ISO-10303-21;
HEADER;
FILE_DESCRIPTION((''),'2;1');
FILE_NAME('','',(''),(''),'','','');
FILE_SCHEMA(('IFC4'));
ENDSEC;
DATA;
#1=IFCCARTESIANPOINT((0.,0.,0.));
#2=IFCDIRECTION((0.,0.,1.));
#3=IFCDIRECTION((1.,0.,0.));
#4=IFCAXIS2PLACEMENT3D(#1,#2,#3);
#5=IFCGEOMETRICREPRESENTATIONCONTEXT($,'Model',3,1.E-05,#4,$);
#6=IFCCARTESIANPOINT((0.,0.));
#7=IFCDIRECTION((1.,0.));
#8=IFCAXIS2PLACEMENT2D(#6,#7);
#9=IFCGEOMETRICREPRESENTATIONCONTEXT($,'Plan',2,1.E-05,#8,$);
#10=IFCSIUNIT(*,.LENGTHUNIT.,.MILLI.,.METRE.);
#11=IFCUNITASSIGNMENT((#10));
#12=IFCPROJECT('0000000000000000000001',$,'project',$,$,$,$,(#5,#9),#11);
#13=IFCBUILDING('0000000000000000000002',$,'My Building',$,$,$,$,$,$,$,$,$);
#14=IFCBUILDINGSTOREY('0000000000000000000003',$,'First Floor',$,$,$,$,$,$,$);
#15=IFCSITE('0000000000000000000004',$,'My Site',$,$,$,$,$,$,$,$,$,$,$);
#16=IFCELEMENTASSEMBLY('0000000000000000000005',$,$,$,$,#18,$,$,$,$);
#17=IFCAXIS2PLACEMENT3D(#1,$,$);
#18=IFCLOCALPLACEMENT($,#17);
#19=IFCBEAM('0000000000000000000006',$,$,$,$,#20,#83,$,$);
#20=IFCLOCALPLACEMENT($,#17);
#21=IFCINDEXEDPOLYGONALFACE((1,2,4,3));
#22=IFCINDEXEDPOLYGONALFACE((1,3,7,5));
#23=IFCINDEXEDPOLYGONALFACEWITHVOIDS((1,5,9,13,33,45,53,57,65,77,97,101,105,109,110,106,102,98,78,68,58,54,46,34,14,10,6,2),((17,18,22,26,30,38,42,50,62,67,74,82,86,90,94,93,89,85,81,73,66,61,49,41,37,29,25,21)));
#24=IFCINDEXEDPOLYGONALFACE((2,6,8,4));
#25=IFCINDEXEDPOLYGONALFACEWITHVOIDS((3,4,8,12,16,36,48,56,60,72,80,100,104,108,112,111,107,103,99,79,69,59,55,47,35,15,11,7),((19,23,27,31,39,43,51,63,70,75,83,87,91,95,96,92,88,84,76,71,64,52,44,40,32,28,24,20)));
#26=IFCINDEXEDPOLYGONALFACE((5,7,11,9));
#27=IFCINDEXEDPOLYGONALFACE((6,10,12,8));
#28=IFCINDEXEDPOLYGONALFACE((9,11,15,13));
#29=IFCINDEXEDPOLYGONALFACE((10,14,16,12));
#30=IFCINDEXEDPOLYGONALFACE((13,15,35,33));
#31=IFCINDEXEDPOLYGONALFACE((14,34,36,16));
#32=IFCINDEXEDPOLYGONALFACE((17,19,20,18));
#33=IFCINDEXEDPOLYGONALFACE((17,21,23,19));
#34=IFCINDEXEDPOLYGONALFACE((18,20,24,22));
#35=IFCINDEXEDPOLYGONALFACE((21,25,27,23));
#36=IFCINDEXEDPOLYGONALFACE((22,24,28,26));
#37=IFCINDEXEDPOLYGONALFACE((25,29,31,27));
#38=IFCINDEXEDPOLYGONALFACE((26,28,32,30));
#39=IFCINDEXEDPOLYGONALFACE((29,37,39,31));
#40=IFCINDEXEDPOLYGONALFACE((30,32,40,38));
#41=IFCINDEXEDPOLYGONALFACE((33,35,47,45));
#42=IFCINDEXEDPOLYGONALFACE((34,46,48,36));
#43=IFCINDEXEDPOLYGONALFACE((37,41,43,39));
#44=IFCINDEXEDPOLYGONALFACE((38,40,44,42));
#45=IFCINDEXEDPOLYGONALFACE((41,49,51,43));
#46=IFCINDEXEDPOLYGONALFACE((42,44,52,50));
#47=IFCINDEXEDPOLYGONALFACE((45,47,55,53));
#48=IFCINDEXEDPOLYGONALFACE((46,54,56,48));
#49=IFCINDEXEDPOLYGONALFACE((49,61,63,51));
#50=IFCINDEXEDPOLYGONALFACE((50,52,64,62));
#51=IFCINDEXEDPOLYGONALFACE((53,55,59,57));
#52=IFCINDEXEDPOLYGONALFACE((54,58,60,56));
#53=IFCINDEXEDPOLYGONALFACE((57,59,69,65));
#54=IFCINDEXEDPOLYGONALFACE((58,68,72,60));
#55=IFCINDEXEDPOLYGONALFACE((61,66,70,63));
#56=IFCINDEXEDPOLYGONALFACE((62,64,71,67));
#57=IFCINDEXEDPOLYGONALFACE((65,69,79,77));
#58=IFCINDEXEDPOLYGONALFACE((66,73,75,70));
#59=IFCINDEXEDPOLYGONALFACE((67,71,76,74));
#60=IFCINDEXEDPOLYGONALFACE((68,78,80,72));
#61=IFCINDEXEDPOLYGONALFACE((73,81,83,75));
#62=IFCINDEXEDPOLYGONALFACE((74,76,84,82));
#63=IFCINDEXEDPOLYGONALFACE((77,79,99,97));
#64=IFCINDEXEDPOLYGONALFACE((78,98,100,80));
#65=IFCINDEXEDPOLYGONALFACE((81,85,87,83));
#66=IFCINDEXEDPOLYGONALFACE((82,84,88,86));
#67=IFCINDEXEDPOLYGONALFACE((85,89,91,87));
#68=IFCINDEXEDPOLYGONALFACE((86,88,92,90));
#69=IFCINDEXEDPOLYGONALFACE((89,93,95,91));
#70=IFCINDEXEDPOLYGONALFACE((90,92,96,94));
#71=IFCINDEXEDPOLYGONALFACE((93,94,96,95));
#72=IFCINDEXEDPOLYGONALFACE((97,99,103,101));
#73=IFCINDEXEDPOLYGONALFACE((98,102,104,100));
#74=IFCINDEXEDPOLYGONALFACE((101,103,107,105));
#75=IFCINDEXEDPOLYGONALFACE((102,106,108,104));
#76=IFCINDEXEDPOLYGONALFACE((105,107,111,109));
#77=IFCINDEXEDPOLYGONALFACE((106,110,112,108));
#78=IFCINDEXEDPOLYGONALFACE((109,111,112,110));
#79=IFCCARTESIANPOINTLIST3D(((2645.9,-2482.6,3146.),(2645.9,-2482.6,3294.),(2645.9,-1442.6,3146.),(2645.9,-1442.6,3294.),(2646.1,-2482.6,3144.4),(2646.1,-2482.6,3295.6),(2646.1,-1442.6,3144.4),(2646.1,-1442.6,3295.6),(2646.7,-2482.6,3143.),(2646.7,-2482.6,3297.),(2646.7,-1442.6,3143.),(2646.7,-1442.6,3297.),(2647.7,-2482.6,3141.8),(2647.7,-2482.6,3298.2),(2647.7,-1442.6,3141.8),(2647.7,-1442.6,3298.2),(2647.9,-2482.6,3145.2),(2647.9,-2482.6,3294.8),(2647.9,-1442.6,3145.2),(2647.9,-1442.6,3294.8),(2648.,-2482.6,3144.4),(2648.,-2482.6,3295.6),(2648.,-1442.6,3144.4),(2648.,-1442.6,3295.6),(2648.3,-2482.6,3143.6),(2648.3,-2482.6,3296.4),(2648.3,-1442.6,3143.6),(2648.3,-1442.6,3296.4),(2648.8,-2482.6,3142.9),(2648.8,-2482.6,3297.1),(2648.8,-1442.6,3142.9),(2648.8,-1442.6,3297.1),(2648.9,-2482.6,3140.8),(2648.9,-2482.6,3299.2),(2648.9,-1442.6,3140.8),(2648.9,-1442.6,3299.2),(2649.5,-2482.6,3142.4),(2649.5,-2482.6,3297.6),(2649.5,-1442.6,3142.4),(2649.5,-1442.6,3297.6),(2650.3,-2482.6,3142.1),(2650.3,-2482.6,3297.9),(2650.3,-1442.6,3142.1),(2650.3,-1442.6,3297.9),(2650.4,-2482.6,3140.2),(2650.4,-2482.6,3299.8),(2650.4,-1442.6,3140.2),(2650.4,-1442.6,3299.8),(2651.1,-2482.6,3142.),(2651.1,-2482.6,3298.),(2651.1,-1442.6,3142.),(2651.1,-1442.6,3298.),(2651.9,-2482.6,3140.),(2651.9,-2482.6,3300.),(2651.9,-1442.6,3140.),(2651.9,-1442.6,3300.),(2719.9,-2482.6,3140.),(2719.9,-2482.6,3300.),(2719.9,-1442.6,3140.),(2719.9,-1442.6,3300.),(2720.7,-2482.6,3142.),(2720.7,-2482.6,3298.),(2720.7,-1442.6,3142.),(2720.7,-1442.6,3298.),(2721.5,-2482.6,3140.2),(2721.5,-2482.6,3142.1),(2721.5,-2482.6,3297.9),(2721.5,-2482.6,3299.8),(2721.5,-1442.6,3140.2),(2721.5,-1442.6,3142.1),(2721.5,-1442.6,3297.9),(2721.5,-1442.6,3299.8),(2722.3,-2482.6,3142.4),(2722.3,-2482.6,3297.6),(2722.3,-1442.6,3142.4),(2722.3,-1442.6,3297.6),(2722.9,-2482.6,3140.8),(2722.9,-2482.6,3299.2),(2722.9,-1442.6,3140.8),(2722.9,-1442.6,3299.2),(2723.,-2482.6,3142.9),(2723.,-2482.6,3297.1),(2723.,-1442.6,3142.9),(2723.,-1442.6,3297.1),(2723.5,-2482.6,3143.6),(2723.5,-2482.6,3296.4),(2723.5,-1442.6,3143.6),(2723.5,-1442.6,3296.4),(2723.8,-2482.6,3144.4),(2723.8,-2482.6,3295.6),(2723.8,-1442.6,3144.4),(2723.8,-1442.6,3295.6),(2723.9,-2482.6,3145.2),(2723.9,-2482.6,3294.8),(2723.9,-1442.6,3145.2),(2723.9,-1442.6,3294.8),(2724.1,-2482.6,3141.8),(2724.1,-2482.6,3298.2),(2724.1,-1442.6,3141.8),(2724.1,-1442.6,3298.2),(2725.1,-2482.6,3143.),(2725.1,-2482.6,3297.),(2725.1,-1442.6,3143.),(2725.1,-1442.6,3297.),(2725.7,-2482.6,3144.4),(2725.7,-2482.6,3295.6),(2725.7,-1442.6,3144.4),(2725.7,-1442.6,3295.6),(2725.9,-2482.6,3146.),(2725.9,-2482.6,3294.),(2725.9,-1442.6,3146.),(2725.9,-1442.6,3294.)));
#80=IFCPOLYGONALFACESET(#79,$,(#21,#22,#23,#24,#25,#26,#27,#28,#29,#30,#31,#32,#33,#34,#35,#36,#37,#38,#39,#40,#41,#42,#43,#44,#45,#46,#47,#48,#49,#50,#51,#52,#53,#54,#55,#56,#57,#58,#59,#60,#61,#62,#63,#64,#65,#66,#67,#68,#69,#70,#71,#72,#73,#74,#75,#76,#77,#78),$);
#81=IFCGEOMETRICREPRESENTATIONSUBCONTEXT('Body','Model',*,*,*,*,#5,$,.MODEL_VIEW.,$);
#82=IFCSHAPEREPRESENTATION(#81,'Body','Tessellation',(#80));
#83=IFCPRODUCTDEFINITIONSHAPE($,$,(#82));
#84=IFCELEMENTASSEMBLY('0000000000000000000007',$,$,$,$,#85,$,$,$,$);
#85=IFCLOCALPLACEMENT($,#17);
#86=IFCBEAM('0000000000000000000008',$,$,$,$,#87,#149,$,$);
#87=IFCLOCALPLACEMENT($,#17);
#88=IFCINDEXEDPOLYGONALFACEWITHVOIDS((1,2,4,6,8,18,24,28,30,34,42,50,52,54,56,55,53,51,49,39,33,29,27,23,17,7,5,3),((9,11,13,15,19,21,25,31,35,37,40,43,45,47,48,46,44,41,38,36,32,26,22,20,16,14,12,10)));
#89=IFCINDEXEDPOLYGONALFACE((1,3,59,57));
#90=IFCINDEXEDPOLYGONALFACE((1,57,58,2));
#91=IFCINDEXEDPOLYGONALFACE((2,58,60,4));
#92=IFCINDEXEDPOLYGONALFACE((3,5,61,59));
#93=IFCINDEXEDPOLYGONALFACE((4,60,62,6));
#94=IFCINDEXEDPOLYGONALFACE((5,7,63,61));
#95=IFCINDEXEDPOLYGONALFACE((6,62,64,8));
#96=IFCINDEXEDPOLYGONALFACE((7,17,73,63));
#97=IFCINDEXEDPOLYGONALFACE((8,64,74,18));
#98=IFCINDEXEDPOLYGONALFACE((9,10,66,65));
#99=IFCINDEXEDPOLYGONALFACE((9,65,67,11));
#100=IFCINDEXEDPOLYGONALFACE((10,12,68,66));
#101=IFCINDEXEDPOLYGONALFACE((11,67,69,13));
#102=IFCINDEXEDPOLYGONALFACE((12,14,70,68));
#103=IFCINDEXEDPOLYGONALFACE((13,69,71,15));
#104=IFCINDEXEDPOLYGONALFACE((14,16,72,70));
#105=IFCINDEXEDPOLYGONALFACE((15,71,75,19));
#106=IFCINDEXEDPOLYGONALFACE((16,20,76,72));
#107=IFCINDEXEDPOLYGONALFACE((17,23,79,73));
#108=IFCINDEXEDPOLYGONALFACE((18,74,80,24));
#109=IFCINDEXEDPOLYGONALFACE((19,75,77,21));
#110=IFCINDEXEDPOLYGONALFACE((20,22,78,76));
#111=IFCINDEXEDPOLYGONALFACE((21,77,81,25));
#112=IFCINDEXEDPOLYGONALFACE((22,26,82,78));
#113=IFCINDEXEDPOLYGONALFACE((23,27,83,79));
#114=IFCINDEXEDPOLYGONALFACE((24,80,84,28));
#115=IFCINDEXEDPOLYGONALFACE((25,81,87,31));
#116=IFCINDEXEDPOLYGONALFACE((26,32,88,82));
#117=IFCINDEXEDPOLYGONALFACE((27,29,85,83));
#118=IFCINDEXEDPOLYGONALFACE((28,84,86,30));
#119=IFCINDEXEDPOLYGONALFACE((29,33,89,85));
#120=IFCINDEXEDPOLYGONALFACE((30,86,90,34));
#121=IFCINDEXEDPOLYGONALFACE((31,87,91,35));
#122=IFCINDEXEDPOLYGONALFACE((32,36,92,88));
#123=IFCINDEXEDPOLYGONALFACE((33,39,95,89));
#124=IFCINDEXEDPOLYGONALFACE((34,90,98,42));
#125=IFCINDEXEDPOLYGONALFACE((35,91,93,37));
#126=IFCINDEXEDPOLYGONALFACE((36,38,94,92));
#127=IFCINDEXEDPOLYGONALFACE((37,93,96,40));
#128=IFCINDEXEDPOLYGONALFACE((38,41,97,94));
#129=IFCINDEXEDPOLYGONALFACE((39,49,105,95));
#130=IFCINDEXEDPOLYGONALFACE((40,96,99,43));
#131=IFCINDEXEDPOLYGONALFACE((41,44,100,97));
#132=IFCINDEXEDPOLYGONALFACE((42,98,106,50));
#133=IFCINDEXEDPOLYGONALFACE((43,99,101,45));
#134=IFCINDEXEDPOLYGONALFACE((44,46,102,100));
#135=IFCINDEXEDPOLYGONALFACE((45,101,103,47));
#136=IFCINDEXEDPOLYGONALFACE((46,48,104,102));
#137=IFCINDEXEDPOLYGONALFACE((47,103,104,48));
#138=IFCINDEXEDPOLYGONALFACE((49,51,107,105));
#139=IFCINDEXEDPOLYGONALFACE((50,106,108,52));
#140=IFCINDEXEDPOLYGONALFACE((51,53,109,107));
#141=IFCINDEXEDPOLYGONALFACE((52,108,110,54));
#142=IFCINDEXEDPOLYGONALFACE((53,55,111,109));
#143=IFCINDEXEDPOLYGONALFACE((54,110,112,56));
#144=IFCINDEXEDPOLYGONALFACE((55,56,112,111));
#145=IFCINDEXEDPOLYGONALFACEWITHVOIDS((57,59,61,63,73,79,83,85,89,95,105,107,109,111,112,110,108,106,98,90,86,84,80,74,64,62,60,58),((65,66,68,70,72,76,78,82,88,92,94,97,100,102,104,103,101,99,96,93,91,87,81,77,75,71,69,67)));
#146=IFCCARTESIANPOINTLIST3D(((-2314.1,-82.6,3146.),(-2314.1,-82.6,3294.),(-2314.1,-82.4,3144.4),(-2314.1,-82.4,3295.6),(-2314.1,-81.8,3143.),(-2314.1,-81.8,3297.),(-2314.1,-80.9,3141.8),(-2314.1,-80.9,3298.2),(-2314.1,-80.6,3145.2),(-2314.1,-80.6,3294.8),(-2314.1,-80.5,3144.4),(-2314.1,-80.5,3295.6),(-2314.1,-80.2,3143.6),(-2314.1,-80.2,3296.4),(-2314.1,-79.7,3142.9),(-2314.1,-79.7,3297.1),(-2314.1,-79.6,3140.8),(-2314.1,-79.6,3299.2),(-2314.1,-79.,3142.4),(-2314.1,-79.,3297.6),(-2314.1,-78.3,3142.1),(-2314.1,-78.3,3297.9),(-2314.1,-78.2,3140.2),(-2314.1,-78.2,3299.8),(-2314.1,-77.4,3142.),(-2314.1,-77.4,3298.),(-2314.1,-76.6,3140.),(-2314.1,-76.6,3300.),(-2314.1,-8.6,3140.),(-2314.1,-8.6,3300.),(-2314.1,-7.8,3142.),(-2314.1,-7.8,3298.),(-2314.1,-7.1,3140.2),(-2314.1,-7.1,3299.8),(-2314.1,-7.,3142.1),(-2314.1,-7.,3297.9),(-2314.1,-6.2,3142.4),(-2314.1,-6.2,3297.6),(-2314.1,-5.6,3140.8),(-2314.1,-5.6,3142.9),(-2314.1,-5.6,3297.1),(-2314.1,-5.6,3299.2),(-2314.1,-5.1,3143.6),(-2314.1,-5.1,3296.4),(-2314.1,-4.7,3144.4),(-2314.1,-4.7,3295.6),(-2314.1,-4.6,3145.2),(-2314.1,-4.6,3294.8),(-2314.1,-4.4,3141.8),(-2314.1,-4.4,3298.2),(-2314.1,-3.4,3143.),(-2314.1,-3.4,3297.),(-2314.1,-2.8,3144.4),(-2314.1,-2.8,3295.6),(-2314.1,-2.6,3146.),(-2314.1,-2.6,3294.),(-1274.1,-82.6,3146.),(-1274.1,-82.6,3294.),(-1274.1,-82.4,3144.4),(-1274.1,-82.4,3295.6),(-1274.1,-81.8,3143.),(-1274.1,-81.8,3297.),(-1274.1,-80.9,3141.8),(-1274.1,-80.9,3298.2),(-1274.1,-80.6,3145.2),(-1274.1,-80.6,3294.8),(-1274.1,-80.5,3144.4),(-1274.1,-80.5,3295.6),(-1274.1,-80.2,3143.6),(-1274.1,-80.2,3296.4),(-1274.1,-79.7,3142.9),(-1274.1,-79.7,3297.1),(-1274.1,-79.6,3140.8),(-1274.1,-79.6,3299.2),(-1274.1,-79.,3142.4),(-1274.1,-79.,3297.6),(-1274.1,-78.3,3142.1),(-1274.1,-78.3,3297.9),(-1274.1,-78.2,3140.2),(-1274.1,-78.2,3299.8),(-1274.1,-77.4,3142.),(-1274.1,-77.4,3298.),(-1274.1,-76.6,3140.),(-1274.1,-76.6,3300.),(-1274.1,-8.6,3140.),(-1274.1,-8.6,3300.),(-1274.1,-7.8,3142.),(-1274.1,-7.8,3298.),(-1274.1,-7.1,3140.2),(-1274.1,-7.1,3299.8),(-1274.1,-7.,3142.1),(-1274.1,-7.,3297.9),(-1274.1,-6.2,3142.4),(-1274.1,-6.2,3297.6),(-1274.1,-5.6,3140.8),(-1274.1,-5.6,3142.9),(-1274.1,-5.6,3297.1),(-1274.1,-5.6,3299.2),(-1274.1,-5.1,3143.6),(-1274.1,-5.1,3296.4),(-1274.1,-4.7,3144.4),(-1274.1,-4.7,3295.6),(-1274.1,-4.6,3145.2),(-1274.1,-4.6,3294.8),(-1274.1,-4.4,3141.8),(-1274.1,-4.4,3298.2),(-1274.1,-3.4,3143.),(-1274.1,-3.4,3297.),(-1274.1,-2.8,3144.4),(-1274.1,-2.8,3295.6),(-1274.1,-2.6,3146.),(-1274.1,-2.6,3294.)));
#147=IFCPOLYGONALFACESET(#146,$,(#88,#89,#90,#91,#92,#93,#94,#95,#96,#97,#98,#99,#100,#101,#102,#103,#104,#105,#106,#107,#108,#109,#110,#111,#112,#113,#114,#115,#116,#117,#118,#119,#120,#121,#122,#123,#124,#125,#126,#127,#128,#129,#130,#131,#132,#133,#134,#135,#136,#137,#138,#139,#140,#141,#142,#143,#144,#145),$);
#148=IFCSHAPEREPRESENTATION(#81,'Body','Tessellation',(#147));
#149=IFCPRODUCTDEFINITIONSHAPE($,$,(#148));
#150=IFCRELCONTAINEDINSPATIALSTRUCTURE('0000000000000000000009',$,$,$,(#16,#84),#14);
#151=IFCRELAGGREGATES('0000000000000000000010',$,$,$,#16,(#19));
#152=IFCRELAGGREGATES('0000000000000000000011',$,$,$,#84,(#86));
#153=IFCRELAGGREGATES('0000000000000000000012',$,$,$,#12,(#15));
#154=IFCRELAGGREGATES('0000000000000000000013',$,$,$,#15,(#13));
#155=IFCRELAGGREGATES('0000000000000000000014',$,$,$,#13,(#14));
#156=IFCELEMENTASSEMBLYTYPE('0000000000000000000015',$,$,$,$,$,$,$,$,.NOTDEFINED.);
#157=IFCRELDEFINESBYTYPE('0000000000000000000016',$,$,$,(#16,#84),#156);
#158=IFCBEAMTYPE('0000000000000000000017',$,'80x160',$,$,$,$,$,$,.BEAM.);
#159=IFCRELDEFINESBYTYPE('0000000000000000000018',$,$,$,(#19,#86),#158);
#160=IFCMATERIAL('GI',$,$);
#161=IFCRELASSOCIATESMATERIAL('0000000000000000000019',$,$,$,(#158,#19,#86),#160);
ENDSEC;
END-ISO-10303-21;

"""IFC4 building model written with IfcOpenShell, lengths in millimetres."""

from ifc_helpers import new_model, si_unit, frame, origin_with_axes, origin_2d_with_axis, place, context, subcontext, project, spatial, hollow_rectangle, extrude, material, material_profile, profile_set, profile_usage, type_object, element, aggregate, save


model = new_model("IFC4")

# Units and contexts
model_context = context("Model", 3, precision=1e-05, world=origin_with_axes())
plan_context = context("Plan", 2, precision=1e-05, world=origin_2d_with_axis())
body_context = subcontext(model_context, "Body", "Model", "MODEL_VIEW")
ifc_project = project(units=[si_unit("LENGTHUNIT", "METRE", prefix="MILLI")], contexts=[model_context, plan_context])

# Site, building, storey
site = spatial("IfcSite", under=ifc_project, Name="My Site")
building = spatial("IfcBuilding", under=site, Name="My Building")
storey = spatial("IfcBuildingStorey", under=building, Name="First Floor")

# Element assemblies, beams
element_assembly_type = type_object("IfcElementAssemblyType", PredefinedType="NOTDEFINED")
ifc_material = material(Name="GI")
ifc_material_profile = material_profile(ifc_material, hollow_rectangle(XDim=80.0, YDim=160.0, WallThickness=2.0, InnerFilletRadius=3.2, OuterFilletRadius=6.0))
ifc_profile_set = profile_set([ifc_material_profile], Name="80x160 GI Rectangular Hollow")
beam_type = type_object("IfcBeamType", Name="80x160", PredefinedType="BEAM", material=ifc_profile_set)
assembly_1_placement = place(None, frame((2685.9, -2562.6, 3220.0), z_axis=(0.0, 1.0, 0.0), x_axis=(1.0, 0.0, 0.0)))
assembly_1 = element("IfcElementAssembly", 1, at=assembly_1_placement, inside=storey, type_object=element_assembly_type)
ifc_profile_usage_1 = profile_usage(ifc_profile_set)
beam_1_placement = place(assembly_1_placement, frame((0.0, 0.0, 80.0), z_axis=(0.0, 0.0, 1.0), x_axis=(1.0, 0.0, 0.0)))
beam_1 = element("IfcBeam", 2, at=beam_1_placement, type_object=beam_type, material=ifc_profile_usage_1, context=body_context, shape_type="SweptSolid", body=[
    extrude(hollow_rectangle(XDim=80.0, YDim=160.0, WallThickness=2.0, InnerFilletRadius=3.2, OuterFilletRadius=6.0), origin_with_axes(), (0.0, 0.0, 1.0), 1040.0),
])
aggregate(assembly_1, [beam_1])
assembly_2_placement = place(None, frame((-2394.1, -42.6, 3220.0), z_axis=(1.0, 0.0, 0.0), x_axis=(0.0, 1.0, 0.0)))
assembly_2 = element("IfcElementAssembly", 3, at=assembly_2_placement, inside=storey, type_object=element_assembly_type)
ifc_profile_usage_2 = profile_usage(ifc_profile_set)
beam_2_placement = place(assembly_2_placement, frame((0.0, 0.0, 80.0), z_axis=(0.0, 0.0, 1.0), x_axis=(1.0, 0.0, 0.0)))
beam_2 = element("IfcBeam", 4, at=beam_2_placement, type_object=beam_type, material=ifc_profile_usage_2, context=body_context, shape_type="SweptSolid", body=[
    extrude(hollow_rectangle(XDim=80.0, YDim=160.0, WallThickness=2.0, InnerFilletRadius=3.2, OuterFilletRadius=6.0), origin_with_axes(), (0.0, 0.0, 1.0), 1040.0),
])
aggregate(assembly_2, [beam_2])

save(model, "model.ifc")
